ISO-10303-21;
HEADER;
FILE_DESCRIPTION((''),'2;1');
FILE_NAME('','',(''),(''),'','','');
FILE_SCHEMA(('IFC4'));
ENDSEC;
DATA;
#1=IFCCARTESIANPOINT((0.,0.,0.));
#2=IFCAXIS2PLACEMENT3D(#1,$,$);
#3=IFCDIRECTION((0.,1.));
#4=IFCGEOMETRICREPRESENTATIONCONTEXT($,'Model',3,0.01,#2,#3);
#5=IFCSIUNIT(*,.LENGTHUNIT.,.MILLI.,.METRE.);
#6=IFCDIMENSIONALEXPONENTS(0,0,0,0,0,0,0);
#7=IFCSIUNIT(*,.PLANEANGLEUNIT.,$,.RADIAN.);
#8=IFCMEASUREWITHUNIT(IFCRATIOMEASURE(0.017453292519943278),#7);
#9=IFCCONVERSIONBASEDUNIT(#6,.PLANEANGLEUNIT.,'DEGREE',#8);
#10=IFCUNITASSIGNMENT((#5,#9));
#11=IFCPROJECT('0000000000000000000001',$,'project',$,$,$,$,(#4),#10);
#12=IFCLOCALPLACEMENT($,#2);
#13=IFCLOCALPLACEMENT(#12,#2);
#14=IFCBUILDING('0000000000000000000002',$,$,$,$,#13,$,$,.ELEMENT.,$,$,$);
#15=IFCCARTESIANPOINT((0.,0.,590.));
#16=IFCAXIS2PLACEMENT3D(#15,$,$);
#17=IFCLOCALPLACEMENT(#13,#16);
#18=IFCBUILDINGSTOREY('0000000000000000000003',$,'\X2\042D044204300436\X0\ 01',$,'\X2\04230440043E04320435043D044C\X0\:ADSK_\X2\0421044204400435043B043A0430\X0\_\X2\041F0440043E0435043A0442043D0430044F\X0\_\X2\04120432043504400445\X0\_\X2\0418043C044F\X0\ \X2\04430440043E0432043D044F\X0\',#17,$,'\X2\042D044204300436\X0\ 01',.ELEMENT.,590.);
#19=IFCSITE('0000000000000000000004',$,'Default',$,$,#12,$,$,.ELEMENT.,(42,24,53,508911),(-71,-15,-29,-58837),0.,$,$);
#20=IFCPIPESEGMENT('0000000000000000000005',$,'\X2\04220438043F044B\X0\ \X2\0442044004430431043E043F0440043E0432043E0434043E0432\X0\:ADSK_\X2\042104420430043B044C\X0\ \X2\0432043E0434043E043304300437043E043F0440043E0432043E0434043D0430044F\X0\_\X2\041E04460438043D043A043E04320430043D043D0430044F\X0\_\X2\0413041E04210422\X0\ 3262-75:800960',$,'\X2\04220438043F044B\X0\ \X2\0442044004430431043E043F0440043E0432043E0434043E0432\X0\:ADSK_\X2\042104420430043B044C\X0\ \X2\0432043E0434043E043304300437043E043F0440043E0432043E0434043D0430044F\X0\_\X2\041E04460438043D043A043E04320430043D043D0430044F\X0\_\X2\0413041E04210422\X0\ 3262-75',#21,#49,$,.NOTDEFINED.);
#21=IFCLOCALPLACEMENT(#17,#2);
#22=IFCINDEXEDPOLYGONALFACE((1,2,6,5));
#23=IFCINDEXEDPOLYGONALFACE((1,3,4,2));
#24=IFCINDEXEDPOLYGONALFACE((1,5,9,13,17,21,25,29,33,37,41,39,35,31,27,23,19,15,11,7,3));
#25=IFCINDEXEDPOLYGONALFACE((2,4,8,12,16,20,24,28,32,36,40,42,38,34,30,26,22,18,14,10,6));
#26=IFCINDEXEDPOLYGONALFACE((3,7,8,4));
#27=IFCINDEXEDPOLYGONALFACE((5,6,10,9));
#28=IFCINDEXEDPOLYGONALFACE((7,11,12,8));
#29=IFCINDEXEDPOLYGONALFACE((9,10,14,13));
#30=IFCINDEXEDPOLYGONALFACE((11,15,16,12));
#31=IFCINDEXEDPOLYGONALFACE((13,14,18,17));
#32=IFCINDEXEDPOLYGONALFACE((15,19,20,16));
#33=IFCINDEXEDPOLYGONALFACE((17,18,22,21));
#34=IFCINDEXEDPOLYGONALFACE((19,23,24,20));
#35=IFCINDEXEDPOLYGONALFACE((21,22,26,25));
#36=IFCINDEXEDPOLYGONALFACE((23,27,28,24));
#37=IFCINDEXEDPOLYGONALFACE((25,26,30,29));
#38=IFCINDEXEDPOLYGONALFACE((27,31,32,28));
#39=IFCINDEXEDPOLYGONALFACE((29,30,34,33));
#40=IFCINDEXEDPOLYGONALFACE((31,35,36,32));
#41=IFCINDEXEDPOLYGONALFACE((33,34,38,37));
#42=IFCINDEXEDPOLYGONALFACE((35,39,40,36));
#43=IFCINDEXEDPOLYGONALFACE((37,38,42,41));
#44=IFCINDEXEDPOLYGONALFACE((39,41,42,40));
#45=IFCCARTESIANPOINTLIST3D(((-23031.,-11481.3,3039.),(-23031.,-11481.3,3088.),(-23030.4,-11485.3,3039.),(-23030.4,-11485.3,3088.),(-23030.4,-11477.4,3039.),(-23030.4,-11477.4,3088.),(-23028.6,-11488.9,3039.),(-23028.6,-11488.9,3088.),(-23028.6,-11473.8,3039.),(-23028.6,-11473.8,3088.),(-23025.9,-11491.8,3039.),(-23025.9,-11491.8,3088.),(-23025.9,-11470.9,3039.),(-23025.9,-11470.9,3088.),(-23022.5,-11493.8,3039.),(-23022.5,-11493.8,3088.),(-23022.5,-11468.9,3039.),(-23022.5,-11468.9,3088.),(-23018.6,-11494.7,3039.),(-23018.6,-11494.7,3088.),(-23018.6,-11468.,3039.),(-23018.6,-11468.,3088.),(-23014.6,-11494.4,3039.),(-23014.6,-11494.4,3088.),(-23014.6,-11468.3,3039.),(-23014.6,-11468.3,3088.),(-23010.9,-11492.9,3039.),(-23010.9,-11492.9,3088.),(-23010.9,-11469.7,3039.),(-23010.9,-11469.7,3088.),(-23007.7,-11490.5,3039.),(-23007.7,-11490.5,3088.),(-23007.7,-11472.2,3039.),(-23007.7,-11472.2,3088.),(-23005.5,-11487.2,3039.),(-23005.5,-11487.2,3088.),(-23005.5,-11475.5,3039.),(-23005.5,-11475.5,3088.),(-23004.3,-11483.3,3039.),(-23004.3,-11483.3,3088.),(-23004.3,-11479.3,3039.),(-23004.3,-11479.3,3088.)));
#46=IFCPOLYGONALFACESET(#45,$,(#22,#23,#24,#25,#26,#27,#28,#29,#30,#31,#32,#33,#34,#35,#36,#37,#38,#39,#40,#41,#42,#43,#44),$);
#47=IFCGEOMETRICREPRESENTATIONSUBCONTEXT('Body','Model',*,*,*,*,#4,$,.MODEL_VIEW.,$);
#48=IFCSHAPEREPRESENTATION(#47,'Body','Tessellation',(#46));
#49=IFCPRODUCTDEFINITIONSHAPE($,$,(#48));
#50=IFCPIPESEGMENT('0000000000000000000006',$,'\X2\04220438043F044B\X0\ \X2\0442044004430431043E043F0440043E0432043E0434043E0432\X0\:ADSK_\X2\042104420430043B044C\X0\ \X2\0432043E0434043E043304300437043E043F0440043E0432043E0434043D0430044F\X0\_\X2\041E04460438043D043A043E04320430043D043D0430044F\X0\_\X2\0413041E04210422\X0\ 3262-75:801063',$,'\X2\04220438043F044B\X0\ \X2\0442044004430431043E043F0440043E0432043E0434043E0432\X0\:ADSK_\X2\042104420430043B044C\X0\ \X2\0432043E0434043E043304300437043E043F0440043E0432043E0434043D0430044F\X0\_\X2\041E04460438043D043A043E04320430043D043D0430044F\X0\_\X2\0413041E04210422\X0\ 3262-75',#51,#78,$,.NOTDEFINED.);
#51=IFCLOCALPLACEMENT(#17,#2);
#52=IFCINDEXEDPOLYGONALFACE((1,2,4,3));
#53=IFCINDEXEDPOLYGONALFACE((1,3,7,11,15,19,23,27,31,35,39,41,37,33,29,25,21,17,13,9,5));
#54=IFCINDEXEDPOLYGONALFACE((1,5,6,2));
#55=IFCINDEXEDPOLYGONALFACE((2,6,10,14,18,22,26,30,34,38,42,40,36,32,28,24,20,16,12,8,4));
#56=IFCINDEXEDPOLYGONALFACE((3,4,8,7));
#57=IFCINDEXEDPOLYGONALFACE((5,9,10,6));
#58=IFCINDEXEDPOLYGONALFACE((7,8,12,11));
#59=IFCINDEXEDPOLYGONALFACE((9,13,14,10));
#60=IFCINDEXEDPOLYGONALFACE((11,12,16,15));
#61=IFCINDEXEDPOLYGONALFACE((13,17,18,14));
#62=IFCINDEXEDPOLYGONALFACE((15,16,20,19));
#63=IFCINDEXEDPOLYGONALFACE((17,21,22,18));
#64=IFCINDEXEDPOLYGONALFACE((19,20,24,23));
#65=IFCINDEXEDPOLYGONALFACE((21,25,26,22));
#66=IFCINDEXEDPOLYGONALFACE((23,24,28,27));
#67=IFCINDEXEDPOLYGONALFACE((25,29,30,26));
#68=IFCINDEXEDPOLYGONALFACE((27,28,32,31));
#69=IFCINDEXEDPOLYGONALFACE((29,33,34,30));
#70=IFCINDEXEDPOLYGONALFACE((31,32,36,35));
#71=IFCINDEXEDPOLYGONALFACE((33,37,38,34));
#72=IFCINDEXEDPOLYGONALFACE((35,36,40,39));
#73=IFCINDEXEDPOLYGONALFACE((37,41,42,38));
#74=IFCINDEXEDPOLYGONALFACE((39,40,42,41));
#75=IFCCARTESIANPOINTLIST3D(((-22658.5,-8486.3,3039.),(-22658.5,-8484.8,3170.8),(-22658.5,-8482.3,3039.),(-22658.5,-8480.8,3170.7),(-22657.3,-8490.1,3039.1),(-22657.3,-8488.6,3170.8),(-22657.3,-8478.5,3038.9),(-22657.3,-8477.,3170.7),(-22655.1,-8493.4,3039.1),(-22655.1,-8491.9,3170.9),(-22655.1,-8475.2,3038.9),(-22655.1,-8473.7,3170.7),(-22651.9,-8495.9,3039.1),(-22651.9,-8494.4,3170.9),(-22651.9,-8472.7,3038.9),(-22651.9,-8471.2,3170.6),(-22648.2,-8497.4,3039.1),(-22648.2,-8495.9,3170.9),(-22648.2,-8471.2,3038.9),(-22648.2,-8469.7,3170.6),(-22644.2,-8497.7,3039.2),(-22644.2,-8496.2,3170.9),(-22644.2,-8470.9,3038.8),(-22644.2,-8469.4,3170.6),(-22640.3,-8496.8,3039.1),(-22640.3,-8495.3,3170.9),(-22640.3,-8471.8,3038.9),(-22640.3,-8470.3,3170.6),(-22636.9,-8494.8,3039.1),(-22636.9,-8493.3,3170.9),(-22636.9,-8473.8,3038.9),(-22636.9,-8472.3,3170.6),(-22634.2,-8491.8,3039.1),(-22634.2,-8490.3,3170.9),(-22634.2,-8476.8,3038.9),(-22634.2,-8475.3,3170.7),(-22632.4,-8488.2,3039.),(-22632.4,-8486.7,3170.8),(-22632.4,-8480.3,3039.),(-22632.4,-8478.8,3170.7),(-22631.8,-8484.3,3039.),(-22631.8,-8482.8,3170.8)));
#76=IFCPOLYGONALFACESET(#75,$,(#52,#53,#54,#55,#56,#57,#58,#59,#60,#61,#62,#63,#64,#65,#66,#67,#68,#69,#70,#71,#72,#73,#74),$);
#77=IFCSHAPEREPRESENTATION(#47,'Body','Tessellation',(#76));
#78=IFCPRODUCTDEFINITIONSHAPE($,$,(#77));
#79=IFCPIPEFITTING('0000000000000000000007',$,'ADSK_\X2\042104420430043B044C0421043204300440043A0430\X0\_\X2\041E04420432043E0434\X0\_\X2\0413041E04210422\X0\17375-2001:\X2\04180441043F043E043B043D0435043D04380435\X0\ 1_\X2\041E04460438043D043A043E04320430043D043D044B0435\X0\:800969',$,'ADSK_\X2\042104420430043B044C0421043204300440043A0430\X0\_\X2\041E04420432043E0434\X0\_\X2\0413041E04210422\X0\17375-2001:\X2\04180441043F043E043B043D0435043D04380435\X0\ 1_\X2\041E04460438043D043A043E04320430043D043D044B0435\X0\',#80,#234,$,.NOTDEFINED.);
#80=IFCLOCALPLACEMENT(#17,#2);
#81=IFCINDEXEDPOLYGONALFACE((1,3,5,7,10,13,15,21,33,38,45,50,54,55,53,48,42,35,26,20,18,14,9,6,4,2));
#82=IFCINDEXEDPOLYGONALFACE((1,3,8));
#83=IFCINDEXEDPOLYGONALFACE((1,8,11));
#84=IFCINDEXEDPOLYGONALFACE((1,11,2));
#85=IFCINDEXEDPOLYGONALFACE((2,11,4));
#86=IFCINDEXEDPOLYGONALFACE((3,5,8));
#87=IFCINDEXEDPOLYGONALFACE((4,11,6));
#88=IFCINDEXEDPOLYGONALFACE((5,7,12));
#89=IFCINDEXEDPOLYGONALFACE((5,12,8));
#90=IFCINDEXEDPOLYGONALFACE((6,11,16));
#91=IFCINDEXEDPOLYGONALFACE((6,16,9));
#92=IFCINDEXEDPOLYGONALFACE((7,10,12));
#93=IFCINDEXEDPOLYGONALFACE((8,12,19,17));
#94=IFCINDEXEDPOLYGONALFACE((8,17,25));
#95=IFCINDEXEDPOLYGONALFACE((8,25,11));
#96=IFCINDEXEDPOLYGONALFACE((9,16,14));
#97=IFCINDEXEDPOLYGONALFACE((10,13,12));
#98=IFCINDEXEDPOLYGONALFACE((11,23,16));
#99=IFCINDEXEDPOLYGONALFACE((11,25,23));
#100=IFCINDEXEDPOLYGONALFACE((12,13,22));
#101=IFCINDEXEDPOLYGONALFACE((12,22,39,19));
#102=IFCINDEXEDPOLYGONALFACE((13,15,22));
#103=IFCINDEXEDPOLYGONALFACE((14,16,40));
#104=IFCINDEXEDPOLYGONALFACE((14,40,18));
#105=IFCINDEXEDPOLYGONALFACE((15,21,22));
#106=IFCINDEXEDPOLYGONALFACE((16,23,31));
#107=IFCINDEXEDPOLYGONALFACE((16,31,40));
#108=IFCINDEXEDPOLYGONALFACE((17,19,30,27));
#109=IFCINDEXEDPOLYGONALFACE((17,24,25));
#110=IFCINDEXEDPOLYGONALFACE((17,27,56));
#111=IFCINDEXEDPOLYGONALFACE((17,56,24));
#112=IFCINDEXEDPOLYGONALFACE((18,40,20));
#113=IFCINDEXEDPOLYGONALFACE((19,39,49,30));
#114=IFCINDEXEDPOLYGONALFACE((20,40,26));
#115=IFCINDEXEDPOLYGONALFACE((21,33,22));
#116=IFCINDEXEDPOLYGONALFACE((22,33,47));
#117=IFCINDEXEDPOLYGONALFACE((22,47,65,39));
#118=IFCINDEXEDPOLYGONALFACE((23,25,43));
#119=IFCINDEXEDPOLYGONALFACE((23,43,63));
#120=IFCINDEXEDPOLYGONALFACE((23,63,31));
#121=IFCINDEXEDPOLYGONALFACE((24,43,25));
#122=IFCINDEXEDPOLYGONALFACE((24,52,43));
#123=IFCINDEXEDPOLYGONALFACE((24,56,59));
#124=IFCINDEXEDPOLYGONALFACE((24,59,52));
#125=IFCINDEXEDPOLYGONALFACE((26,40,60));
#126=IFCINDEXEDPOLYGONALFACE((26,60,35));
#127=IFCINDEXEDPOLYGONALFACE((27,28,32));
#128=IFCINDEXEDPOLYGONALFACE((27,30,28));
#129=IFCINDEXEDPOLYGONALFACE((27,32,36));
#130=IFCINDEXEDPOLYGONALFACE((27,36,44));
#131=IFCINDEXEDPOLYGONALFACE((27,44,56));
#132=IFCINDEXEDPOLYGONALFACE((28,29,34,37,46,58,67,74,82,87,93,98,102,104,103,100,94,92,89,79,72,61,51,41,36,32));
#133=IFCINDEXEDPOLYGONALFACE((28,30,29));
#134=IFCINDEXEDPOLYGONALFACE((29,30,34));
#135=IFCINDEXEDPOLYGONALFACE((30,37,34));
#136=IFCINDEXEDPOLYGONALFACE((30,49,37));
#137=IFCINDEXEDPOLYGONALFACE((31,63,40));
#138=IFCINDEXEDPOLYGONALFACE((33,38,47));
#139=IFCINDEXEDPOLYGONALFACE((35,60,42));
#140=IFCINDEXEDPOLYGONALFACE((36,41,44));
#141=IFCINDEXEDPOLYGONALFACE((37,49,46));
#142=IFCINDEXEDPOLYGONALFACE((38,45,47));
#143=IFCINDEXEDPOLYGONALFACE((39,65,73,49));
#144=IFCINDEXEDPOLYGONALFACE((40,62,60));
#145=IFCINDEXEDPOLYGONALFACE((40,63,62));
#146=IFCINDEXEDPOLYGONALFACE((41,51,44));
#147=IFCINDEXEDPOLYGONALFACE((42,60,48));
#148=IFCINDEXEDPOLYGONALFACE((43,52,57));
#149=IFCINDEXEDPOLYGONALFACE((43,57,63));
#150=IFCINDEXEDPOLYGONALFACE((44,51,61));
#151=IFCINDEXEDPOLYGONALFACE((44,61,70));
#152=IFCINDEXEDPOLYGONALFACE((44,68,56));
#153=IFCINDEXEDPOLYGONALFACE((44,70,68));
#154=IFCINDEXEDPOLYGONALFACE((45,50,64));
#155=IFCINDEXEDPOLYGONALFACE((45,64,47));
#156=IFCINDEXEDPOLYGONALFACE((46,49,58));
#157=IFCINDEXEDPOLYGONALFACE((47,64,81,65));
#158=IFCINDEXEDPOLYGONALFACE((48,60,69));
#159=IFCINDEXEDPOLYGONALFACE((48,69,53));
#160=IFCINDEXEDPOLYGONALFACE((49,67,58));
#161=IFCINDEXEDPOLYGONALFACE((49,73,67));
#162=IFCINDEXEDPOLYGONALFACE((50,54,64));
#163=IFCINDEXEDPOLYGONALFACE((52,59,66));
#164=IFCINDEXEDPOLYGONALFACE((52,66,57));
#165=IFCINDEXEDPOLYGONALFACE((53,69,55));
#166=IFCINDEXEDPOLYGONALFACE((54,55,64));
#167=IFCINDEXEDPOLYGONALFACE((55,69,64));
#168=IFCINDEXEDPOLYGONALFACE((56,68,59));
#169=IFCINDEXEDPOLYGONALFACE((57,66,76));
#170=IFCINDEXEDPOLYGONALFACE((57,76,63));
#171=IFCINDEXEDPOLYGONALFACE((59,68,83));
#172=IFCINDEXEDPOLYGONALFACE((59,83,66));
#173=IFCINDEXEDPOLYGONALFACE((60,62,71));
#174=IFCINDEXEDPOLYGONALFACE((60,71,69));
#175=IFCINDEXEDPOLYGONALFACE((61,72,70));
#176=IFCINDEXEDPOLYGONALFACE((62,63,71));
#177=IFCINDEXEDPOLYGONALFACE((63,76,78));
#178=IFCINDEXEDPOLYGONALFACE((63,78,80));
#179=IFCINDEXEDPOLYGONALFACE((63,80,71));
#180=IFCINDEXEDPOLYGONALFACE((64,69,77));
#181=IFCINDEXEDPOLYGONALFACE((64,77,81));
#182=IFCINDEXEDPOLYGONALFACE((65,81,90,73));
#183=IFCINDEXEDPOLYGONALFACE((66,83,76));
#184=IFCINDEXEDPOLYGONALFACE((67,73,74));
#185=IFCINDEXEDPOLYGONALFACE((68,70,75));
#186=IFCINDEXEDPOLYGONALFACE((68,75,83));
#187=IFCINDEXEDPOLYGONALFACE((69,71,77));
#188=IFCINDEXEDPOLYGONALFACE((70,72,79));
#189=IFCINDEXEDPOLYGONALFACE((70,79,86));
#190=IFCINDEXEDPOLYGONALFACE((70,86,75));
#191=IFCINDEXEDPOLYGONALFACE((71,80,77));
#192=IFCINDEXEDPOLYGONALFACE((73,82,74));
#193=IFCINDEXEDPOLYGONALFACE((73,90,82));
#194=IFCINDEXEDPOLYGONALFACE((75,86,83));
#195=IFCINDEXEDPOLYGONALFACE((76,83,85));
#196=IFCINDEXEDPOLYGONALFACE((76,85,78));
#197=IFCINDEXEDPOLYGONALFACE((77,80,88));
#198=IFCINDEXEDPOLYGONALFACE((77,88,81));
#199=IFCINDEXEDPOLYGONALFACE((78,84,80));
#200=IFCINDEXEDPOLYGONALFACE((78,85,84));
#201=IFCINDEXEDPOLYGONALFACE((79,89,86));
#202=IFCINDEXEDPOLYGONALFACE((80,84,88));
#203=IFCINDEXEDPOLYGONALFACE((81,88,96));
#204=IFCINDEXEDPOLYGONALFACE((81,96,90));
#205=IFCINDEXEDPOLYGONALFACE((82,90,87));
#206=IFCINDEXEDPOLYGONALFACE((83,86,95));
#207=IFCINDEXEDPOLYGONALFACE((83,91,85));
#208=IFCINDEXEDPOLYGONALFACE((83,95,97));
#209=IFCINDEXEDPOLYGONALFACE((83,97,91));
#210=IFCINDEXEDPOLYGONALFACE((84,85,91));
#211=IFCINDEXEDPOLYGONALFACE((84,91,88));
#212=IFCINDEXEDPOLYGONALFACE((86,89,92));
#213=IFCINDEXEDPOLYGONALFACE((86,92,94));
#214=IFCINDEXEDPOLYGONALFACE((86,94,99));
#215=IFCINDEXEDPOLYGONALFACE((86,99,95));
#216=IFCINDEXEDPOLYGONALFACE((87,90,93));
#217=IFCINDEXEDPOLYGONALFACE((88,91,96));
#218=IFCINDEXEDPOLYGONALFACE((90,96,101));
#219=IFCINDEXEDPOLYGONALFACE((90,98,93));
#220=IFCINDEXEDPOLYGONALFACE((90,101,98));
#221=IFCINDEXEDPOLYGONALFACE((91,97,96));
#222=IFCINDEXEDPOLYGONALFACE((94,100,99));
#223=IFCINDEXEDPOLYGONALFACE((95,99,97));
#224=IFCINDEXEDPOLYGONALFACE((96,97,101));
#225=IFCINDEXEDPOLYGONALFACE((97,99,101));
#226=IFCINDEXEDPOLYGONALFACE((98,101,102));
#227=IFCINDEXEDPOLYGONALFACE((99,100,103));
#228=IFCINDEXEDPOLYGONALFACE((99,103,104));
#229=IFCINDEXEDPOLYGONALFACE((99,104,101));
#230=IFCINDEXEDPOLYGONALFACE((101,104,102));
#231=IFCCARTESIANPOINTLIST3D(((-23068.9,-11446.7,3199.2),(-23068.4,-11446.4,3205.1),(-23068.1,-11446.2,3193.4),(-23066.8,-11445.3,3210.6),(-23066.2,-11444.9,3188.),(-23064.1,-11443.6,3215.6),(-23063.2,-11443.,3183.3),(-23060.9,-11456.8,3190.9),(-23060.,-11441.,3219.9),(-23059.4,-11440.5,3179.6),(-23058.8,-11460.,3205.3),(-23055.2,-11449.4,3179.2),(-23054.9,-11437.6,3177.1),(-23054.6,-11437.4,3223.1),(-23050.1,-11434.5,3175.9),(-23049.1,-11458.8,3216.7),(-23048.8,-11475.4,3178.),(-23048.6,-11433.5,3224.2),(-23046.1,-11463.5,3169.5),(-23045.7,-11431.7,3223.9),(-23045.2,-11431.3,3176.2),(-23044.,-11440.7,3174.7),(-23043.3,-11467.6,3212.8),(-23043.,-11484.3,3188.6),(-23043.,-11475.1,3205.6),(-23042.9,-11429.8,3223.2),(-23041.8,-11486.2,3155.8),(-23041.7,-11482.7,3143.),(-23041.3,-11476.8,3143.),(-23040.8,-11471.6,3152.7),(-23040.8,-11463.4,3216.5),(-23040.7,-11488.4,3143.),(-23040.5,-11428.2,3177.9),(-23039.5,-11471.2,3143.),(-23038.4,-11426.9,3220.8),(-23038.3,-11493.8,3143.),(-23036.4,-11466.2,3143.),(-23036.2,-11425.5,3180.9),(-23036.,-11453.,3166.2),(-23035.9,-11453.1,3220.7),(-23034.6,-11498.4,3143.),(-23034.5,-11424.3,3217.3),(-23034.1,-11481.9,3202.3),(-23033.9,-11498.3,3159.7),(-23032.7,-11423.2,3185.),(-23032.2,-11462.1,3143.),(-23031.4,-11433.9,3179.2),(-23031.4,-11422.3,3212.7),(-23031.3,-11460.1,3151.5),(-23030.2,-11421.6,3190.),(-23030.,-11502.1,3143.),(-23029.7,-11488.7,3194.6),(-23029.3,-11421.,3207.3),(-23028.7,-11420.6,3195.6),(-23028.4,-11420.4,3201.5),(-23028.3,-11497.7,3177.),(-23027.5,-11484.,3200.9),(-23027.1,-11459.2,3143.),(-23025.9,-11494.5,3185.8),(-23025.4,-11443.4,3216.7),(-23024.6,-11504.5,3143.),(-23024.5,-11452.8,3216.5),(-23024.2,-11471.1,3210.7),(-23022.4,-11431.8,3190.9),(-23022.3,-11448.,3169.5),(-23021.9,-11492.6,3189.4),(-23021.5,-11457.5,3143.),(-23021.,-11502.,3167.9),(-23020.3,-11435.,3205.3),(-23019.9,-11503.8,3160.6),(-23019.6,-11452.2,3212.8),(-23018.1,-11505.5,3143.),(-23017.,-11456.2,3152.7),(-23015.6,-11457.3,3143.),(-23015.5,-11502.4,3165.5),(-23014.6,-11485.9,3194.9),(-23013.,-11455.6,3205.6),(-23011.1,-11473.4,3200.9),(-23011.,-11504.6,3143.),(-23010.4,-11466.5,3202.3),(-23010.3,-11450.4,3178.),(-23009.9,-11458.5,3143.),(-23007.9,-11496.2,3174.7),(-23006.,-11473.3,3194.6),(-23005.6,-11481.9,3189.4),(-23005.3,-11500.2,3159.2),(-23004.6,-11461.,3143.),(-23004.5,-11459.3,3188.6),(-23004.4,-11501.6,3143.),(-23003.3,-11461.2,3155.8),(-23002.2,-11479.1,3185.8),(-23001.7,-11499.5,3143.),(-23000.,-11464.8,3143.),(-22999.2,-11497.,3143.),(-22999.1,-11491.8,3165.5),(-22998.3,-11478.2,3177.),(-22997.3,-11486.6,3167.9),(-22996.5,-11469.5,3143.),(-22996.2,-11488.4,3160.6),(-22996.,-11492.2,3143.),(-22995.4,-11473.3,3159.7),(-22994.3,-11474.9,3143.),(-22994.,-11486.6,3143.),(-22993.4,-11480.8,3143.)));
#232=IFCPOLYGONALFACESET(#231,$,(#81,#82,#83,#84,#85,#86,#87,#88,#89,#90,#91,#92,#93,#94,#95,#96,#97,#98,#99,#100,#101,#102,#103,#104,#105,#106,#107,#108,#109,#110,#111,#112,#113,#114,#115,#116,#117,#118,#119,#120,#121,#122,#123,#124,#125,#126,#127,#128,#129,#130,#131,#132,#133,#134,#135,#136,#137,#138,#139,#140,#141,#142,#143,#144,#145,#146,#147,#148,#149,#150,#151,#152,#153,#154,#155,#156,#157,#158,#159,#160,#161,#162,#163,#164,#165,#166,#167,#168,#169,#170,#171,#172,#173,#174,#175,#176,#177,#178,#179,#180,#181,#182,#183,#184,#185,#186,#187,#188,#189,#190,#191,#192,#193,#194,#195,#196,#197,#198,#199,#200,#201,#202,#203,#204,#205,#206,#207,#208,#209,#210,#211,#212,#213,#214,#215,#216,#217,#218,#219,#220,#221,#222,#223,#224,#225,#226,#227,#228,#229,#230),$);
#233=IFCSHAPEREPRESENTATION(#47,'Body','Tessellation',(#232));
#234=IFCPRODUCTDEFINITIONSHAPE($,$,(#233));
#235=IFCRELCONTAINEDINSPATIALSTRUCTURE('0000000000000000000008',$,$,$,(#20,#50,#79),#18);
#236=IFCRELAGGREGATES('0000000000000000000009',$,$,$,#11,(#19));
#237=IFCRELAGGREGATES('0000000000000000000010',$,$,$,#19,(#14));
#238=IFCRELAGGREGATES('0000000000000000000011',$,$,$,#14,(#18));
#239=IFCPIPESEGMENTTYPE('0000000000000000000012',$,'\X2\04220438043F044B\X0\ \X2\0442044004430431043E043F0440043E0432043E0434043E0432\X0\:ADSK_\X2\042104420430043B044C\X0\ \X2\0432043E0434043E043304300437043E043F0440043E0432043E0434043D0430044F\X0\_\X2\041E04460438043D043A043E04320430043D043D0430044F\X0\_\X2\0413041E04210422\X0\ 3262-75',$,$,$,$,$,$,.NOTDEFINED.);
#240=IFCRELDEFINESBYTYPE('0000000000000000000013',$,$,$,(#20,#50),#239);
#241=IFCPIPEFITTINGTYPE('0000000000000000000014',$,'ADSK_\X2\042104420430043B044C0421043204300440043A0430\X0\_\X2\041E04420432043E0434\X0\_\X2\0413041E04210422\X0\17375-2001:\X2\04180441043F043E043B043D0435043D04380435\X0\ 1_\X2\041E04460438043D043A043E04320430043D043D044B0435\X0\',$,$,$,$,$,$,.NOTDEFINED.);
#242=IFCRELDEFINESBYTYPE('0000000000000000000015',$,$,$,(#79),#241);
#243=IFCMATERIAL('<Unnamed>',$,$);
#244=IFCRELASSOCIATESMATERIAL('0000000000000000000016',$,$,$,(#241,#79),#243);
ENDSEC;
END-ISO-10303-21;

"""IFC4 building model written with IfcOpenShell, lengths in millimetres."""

from ifc_helpers import new_model, entity, si_unit, converted_unit, direction, frame, frame_2d, origin, origin_2d_with_axis, place, context, subcontext, project, spatial, circle, extrude, source, transform, mapped, material, type_object, type_shapes, element, save


model = new_model("IFC4")

# Units and contexts
model_context = context("Model", 3, precision=0.01, world=origin(), true_north=direction((0.0, 1.0)))
body_context = subcontext(model_context, "Body", "Model", "MODEL_VIEW")
ifc_project = project(units=[si_unit("LENGTHUNIT", "METRE", prefix="MILLI"), converted_unit("PLANEANGLEUNIT", "DEGREE", entity("IfcRatioMeasure", 0.017453292519943278), si_unit("PLANEANGLEUNIT", "RADIAN"), dimensions=[0, 0, 0, 0, 0, 0, 0])], contexts=[model_context])

# Site, building, storey
site_placement = place(None, origin())
site = spatial("IfcSite", under=ifc_project, at=site_placement, Name="Default", CompositionType="ELEMENT", RefLatitude=(42, 24, 53, 508911), RefLongitude=(-71, -15, -29, -58837), RefElevation=0.0)
building_placement = place(site_placement, origin())
building = spatial("IfcBuilding", under=site, at=building_placement, CompositionType="ELEMENT")
storey_placement = place(building_placement, frame((0.0, 0.0, 590.0)))
storey = spatial("IfcBuildingStorey", under=building, at=storey_placement, Name="Этаж 01", ObjectType="Уровень:ADSK_Стрелка_Проектная_Вверх_Имя уровня", LongName="Этаж 01", CompositionType="ELEMENT", Elevation=590.0)

# Shared definitions
ifc_material_1 = material(Name="<Unnamed>")

# Pipe segments
pipe_segment_type = type_object("IfcPipeSegmentType", Name="Типы трубопроводов:ADSK_Сталь водогазопроводная_Оцинкованная_ГОСТ 3262-75", PredefinedType="NOTDEFINED")
pipe_segment_1_placement = place(storey_placement, frame((-23032.6, -11496.3, 3088.0)))
element("IfcPipeSegment", 1, at=pipe_segment_1_placement, inside=storey, type_object=pipe_segment_type, Name="Типы трубопроводов:ADSK_Сталь водогазопроводная_Оцинкованная_ГОСТ 3262-75:800960", ObjectType="Типы трубопроводов:ADSK_Сталь водогазопроводная_Оцинкованная_ГОСТ 3262-75", PredefinedType="NOTDEFINED", context=body_context, shape_type="SweptSolid", body=[
    extrude(circle(Radius=13.4, at=frame_2d((0.0, 0.0), x_axis=(1.0, 0.0))), frame((15.0, 15.0, -49.0), z_axis=(0.0, 0.0, 1.0), x_axis=(-1.0, 0.0, 0.0)), (0.0, 0.0, 1.0), 49.0),
])
pipe_segment_2_placement = place(storey_placement, frame((-22660.2, -8499.3, 3038.8)))
element("IfcPipeSegment", 2, at=pipe_segment_2_placement, inside=storey, type_object=pipe_segment_type, Name="Типы трубопроводов:ADSK_Сталь водогазопроводная_Оцинкованная_ГОСТ 3262-75:801063", ObjectType="Типы трубопроводов:ADSK_Сталь водогазопроводная_Оцинкованная_ГОСТ 3262-75", PredefinedType="NOTDEFINED", context=body_context, shape_type="SweptSolid", body=[
    extrude(circle(Radius=13.4, at=origin_2d_with_axis()), frame((15.0, 15.0, 0.2), z_axis=(0.0, 0.011382, 0.999935), x_axis=(1.0, 0.0, 0.0)), (0.0, 0.0, 1.0), 131.8),
])

# Pipe fitting
pipe_fitting_type_1 = type_object("IfcPipeFittingType", Name="ADSK_СтальСварка_Отвод_ГОСТ17375-2001:Исполнение 1_Оцинкованные", PredefinedType="NOTDEFINED", material=ifc_material_1)
ifc_direction_1 = entity("IfcDirection", [0.0, 0.0, 1.0])
trimmed_curve_1 = entity("IfcTrimmedCurve", entity("IfcCircle", entity("IfcAxis2Placement2D", entity("IfcCartesianPoint", [-57.0, 0.0]), entity("IfcDirection", [0.0, 1.0])), 57.0), [entity("IfcParameterValue", 270.0)], [entity("IfcParameterValue", 0.0)], True, "PARAMETER")
shared_shape_1 = source(origin(), body_context, "Body", "AdvancedSweptSolid", [
    entity("IfcSurfaceCurveSweptAreaSolid", entity("IfcCircleProfileDef", "AREA", None, entity("IfcAxis2Placement2D", entity("IfcCartesianPoint", [0.0, 0.0]), entity("IfcDirection", [1.0, 0.0])), 24.1), entity("IfcAxis2Placement3D", entity("IfcCartesianPoint", [-57.0, 0.0, 0.0]), ifc_direction_1, entity("IfcDirection", [0.0, -1.0, 0.0])), trimmed_curve_1, 0.0, 90.0, entity("IfcSurfaceOfLinearExtrusion", entity("IfcArbitraryOpenProfileDef", "CURVE", None, trimmed_curve_1), entity("IfcAxis2Placement3D", entity("IfcCartesianPoint", [0.0, 0.0, -304.8])), ifc_direction_1, 1.0)),
])
type_shapes(pipe_fitting_type_1, [shared_shape_1])
pipe_fitting_1_placement = place(storey_placement, frame((-23017.6, -11481.3, 3200.0), z_axis=(0.838671, 0.544639, 0.0), x_axis=(0.544639, -0.838671, 0.0)))
element("IfcPipeFitting", 3, at=pipe_fitting_1_placement, inside=storey, type_object=pipe_fitting_type_1, material=ifc_material_1, Name="ADSK_СтальСварка_Отвод_ГОСТ17375-2001:Исполнение 1_Оцинкованные:800969", ObjectType="ADSK_СтальСварка_Отвод_ГОСТ17375-2001:Исполнение 1_Оцинкованные", PredefinedType="NOTDEFINED", context=body_context, shape_type="MappedRepresentation", body=[
    mapped(shared_shape_1, transform((0.0, 0.0, 0.0), scale=1.0)),
])

save(model, "model.ifc")
